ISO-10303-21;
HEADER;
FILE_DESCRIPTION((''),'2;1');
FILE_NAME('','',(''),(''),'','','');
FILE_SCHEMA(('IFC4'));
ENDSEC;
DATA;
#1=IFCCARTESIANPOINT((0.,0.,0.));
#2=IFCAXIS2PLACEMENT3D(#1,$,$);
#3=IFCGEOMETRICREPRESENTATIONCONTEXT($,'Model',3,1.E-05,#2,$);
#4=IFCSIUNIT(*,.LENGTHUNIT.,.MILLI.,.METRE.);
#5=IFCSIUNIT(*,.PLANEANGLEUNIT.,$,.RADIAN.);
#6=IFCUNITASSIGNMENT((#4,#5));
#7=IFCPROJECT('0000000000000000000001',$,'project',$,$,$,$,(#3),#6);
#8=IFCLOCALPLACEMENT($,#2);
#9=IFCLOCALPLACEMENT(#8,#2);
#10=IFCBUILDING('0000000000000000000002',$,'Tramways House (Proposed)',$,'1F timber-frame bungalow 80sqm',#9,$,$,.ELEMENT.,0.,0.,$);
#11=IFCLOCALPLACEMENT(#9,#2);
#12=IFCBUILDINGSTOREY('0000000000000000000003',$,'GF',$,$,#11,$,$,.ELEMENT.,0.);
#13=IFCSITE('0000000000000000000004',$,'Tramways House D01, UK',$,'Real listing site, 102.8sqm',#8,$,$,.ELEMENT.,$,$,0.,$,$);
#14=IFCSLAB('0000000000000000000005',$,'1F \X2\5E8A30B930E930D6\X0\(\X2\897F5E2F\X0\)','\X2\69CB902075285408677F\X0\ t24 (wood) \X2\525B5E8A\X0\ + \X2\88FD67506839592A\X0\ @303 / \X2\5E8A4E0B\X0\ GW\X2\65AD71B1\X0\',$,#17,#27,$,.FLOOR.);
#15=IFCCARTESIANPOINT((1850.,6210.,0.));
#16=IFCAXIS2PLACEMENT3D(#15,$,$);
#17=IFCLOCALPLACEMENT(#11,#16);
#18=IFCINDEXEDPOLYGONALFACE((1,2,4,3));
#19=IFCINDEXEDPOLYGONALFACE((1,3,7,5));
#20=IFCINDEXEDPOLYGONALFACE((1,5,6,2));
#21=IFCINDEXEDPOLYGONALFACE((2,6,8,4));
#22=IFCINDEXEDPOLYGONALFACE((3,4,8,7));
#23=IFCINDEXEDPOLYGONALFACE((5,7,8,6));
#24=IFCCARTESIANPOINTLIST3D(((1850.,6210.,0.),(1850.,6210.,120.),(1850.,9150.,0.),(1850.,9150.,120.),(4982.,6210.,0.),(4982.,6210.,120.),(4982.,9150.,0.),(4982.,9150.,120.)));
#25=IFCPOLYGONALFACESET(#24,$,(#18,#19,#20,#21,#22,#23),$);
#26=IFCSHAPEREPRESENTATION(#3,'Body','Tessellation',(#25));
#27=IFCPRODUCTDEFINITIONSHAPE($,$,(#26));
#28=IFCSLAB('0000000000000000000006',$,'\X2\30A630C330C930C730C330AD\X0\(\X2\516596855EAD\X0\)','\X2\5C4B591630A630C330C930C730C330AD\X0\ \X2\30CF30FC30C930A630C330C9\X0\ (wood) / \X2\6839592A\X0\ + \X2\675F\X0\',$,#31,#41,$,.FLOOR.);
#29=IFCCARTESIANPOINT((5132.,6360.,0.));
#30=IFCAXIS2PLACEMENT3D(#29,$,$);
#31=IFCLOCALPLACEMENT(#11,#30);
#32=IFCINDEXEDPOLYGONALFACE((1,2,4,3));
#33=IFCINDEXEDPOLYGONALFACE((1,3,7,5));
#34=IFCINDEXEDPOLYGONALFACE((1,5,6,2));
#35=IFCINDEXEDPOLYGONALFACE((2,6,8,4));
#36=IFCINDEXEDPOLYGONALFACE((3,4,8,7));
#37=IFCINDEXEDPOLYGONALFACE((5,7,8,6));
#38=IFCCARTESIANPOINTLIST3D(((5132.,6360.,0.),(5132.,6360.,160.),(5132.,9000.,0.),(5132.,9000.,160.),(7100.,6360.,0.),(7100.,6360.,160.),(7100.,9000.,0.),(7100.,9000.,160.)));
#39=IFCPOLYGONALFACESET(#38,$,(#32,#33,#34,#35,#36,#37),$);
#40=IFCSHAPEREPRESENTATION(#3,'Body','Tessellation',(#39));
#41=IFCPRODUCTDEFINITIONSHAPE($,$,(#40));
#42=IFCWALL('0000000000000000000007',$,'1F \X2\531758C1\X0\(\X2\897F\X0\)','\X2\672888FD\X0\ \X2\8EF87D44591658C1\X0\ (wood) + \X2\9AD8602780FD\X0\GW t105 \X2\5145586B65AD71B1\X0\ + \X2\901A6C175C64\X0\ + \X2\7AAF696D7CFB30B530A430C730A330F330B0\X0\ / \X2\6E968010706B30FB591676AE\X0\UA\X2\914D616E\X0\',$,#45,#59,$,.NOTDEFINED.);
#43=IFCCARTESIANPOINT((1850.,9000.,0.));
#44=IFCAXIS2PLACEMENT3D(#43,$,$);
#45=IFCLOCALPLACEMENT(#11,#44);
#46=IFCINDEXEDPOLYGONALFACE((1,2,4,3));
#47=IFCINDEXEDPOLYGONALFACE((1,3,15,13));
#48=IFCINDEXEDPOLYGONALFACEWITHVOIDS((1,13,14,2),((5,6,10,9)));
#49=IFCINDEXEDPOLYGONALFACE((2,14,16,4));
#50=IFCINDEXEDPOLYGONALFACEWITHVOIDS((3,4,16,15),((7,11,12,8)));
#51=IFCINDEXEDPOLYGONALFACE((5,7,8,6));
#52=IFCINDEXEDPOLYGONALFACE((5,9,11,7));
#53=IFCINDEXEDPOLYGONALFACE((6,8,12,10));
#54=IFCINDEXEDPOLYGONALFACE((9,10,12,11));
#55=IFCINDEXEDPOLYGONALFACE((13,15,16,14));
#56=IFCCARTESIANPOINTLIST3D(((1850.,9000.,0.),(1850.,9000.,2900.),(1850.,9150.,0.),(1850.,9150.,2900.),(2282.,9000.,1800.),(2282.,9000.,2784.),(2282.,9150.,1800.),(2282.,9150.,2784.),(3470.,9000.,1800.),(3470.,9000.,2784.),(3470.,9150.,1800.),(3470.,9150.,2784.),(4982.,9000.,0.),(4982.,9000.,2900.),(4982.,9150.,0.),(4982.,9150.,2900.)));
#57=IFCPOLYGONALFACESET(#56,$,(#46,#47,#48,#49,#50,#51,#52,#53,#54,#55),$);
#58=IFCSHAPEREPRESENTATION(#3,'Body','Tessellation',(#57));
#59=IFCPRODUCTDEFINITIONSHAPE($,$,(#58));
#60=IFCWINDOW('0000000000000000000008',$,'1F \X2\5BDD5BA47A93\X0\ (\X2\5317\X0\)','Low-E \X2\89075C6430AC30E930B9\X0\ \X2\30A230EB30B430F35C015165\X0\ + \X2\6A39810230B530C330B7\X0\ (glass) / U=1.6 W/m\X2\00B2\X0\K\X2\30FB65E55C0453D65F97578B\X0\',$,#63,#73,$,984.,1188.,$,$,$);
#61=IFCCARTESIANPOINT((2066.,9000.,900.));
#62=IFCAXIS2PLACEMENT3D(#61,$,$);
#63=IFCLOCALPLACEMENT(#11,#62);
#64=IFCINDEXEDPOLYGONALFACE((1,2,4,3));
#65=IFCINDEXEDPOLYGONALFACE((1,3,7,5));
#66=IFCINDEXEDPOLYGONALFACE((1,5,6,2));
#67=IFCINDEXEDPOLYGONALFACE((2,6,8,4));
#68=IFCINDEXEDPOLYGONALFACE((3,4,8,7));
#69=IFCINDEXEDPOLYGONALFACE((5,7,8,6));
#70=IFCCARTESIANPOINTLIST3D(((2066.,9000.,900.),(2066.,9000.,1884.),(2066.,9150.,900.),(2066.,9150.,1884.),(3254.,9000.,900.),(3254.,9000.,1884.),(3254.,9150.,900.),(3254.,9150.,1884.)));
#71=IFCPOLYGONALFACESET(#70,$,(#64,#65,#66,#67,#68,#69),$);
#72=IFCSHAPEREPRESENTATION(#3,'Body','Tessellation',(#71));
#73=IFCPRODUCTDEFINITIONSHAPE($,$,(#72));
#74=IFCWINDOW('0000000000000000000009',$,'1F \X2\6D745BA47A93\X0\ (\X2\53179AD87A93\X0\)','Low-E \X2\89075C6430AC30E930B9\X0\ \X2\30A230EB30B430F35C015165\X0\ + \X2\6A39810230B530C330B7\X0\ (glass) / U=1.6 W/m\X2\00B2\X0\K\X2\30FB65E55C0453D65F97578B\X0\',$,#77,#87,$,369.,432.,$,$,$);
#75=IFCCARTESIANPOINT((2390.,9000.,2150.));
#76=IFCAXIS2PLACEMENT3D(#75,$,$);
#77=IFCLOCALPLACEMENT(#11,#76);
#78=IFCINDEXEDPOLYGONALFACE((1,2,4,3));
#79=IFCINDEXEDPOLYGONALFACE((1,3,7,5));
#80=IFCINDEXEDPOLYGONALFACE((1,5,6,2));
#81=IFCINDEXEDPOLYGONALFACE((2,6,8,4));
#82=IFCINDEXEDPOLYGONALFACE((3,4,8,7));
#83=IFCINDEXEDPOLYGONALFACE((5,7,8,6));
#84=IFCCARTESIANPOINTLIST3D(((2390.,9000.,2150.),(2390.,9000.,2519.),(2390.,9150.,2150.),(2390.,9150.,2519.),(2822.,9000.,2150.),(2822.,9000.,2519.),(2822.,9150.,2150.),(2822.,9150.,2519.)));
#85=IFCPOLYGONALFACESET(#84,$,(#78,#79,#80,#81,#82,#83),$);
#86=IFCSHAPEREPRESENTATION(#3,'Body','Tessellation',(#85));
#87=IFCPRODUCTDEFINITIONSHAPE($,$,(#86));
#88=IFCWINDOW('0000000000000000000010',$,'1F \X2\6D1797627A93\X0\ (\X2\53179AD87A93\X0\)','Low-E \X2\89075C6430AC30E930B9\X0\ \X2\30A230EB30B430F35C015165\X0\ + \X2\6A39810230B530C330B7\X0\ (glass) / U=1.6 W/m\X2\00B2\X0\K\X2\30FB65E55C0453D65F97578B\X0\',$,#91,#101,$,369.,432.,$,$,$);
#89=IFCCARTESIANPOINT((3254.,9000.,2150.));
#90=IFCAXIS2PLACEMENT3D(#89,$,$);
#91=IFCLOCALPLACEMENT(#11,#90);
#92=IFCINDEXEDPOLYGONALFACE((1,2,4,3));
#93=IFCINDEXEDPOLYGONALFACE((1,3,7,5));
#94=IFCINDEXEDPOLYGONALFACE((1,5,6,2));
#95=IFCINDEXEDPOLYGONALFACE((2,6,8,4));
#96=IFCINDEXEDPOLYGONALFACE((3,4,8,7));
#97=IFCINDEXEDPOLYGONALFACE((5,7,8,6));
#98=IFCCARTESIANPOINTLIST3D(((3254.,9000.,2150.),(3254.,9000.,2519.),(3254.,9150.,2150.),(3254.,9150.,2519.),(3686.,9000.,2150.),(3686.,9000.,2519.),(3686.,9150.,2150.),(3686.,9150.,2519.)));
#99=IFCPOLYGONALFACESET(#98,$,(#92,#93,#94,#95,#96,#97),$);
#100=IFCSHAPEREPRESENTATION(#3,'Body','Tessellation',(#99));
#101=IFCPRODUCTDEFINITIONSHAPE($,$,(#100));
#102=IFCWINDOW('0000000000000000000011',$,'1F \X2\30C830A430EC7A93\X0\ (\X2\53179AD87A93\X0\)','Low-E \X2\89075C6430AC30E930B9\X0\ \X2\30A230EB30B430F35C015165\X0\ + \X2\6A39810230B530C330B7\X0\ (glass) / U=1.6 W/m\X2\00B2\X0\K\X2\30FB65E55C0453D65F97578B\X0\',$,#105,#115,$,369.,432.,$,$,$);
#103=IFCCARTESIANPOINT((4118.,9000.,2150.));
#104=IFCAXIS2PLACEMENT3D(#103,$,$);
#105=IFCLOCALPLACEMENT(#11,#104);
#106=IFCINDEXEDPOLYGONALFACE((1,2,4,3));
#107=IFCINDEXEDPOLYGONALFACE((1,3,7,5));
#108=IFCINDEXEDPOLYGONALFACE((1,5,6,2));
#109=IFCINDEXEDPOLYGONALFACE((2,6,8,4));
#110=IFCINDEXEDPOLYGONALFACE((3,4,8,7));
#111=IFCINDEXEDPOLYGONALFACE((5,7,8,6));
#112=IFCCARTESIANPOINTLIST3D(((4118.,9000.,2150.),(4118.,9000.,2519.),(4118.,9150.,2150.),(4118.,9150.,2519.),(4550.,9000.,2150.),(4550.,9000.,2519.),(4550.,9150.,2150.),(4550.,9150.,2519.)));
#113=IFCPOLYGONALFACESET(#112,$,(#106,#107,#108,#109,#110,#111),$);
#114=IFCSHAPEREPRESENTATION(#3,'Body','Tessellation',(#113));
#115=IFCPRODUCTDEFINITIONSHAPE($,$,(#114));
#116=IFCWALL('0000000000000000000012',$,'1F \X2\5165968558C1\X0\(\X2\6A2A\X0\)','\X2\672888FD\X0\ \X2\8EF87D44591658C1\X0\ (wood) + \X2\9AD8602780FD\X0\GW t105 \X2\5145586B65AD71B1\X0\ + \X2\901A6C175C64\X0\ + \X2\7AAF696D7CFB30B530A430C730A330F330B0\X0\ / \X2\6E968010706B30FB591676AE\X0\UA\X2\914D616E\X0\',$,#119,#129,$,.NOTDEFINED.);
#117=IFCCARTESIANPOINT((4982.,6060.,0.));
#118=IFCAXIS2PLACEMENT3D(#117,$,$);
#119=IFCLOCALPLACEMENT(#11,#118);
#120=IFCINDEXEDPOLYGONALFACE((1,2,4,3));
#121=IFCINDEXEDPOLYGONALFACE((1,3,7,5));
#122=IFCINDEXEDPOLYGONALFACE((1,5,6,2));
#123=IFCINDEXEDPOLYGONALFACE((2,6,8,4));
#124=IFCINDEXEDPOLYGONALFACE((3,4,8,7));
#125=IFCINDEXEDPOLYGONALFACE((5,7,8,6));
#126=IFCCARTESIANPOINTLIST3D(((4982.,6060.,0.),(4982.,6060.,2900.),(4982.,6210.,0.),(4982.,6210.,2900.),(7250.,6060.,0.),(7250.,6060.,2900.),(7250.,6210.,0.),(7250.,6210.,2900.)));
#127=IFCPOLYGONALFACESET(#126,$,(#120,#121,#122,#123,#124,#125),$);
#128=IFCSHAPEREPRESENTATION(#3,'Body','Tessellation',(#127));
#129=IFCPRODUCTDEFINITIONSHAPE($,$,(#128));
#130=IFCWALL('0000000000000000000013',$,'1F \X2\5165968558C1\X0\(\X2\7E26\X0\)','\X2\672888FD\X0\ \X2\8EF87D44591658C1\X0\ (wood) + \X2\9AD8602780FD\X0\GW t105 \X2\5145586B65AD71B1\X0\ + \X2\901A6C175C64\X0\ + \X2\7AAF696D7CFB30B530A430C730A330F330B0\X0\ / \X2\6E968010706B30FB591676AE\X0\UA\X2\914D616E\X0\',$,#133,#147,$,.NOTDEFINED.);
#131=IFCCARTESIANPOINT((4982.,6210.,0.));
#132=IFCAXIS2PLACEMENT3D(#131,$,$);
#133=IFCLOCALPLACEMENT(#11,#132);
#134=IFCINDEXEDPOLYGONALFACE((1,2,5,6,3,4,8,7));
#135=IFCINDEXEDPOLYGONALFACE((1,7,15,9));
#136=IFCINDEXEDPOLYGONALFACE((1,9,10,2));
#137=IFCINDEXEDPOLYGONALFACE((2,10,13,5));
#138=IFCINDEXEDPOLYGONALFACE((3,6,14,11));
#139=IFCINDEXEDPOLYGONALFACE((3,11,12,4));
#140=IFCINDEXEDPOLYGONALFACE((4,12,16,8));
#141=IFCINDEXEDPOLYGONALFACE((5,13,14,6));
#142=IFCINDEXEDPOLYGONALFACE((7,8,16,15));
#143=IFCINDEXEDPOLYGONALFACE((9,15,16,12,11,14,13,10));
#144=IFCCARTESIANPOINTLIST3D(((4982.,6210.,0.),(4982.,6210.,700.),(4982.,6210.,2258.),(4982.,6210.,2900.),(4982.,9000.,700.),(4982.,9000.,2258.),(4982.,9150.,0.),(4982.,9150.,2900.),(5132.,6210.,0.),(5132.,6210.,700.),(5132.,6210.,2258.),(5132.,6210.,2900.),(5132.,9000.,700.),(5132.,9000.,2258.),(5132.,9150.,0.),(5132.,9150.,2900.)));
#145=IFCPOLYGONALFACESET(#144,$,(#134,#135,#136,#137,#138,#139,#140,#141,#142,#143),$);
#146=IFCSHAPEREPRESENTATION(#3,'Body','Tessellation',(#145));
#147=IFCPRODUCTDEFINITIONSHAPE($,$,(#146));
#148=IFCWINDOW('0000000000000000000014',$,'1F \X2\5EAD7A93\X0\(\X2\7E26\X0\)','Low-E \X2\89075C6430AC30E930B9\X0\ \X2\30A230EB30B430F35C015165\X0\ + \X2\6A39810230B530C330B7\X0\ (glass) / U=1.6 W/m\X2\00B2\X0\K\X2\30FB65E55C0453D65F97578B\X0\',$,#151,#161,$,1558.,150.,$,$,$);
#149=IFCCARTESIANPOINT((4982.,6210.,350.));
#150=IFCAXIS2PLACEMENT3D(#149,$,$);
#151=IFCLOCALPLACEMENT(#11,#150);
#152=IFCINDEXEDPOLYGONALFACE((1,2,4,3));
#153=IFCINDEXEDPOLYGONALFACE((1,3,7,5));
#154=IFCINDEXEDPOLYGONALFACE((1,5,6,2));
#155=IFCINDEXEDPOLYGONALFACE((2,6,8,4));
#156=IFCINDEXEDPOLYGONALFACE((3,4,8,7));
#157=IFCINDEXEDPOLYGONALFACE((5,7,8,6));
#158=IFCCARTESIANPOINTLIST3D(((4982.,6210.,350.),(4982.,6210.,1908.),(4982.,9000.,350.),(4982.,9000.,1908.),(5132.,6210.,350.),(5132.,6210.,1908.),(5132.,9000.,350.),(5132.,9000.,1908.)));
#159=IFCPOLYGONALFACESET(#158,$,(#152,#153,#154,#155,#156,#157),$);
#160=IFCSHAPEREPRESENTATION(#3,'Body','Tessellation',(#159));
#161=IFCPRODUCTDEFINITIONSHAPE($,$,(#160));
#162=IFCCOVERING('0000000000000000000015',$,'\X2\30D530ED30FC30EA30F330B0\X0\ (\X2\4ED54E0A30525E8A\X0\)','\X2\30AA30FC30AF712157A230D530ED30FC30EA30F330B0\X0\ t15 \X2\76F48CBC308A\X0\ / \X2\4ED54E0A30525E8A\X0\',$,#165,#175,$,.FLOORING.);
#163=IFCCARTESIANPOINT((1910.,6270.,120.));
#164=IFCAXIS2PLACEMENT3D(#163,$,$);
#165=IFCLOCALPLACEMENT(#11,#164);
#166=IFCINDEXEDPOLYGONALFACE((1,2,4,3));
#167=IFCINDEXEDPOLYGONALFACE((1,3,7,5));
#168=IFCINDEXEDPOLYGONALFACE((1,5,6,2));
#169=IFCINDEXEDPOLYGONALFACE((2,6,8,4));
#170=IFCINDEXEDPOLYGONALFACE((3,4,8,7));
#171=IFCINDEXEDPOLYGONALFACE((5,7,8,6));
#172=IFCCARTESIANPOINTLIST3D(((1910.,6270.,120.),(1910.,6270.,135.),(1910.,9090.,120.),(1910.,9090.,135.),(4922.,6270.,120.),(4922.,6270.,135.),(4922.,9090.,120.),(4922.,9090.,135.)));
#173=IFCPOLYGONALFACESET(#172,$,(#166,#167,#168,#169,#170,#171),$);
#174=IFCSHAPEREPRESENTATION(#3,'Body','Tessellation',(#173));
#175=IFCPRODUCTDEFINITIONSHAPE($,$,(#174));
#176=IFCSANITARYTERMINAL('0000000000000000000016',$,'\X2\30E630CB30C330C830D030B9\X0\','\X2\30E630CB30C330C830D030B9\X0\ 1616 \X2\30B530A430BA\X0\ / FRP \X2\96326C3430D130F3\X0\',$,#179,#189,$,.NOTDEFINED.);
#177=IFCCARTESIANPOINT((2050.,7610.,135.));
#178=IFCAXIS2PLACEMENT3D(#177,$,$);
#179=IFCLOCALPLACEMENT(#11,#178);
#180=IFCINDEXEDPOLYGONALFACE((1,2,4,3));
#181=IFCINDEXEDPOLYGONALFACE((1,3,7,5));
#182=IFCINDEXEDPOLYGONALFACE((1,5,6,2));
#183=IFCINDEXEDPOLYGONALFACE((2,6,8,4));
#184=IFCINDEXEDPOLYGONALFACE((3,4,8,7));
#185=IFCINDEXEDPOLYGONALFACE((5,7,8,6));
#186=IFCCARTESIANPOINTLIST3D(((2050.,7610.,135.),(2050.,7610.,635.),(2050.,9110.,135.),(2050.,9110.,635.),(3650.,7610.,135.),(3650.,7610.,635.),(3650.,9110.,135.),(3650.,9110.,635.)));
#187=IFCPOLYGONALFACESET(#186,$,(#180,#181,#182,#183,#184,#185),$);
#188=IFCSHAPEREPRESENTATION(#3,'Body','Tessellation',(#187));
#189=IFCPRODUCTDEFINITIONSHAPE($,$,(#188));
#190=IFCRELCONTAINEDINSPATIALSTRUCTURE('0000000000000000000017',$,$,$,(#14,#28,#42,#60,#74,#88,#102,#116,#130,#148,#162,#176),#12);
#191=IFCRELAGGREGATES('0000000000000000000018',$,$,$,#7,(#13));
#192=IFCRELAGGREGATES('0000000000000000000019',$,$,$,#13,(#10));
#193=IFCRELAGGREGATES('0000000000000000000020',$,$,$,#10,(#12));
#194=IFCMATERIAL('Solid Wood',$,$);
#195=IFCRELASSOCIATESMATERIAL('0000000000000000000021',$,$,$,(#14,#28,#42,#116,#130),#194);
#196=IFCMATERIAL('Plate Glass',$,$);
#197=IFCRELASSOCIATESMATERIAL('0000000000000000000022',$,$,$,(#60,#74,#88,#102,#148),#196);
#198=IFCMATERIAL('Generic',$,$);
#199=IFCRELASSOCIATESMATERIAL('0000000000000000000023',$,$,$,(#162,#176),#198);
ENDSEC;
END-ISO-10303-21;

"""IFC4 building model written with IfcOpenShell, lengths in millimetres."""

from ifc_helpers import new_model, si_unit, frame, frame_2d, origin, place, context, project, spatial, rectangle, extrude, material, element, fill, save


model = new_model("IFC4")

# Units and contexts
model_context = context("Model", 3, precision=1e-05, world=origin())
ifc_project = project(units=[si_unit("LENGTHUNIT", "METRE", prefix="MILLI"), si_unit("PLANEANGLEUNIT", "RADIAN")], contexts=[model_context])

# Site, building, storey
site_placement = place(None, origin())
site = spatial("IfcSite", under=ifc_project, at=site_placement, Name="Tramways House D01, UK", ObjectType="Real listing site, 102.8sqm", CompositionType="ELEMENT", RefElevation=0.0)
building_placement = place(site_placement, origin())
building = spatial("IfcBuilding", under=site, at=building_placement, Name="Tramways House (Proposed)", ObjectType="1F timber-frame bungalow 80sqm", CompositionType="ELEMENT", ElevationOfRefHeight=0.0, ElevationOfTerrain=0.0)
storey_placement = place(building_placement, origin())
storey = spatial("IfcBuildingStorey", under=building, at=storey_placement, Name="GF", CompositionType="ELEMENT", Elevation=0.0)

# Slabs
ifc_material_1 = material(Name="Solid Wood")
slab_1_placement = place(storey_placement, frame((1850.0, 6210.0, 0.0)))
element("IfcSlab", 1, at=slab_1_placement, inside=storey, material=ifc_material_1, Name="1F 床スラブ(西帯)", Description="構造用合板 t24 (wood) 剛床 + 製材根太 @303 / 床下 GW断熱", PredefinedType="FLOOR", context=model_context, shape_type="SweptSolid", body=[
    extrude(rectangle(XDim=3132.0, YDim=2940.0, at=frame_2d((1566.0, 1470.0))), frame((1850.0, 6210.0, 0.0)), (0.0, 0.0, 1.0), 120.0),
])
slab_2_placement = place(storey_placement, frame((5132.0, 6360.0, 0.0)))
element("IfcSlab", 2, at=slab_2_placement, inside=storey, material=ifc_material_1, Name="ウッドデッキ(入隅庭)", Description="屋外ウッドデッキ ハードウッド (wood) / 根太 + 束", PredefinedType="FLOOR", context=model_context, shape_type="SweptSolid", body=[
    extrude(rectangle(XDim=1968.0, YDim=2640.0, at=frame_2d((984.0, 1320.0))), frame((5132.0, 6360.0, 0.0)), (0.0, 0.0, 1.0), 160.0),
])

# Wall, openings, windows
wall_1_placement = place(storey_placement, frame((1850.0, 9000.0, 0.0)))
wall_1 = element("IfcWall", 3, at=wall_1_placement, inside=storey, material=ifc_material_1, Name="1F 北壁(西)", Description="木製 軸組外壁 (wood) + 高性能GW t105 充填断熱 + 通気層 + 窯業系サイディング / 準耐火・外皮UA配慮", PredefinedType="NOTDEFINED", context=model_context, shape_type="SweptSolid", body=[
    extrude(rectangle(XDim=3132.0, YDim=150.0, at=frame_2d((1566.0, 75.0))), frame((1850.0, 9000.0, 0.0)), (0.0, 0.0, 1.0), 2900.0),
])
opening_1_placement = place(storey_placement, frame((2066.0, 9000.0, 900.0)))
opening_1 = element("IfcOpeningElement", 4, at=opening_1_placement, cuts=wall_1, PredefinedType="NOTDEFINED", context=model_context, shape_type="SweptSolid", body=[
    extrude(rectangle(XDim=1188.0, YDim=150.0, at=frame_2d((594.0, 75.0))), frame((2066.0, 9000.0, 900.0)), (0.0, 0.0, 1.0), 984.0),
])
opening_2_placement = place(storey_placement, frame((2390.0, 9000.0, 2150.0)))
opening_2 = element("IfcOpeningElement", 5, at=opening_2_placement, cuts=wall_1, PredefinedType="NOTDEFINED", context=model_context, shape_type="SweptSolid", body=[
    extrude(rectangle(XDim=432.0, YDim=150.0, at=frame_2d((216.0, 75.0))), frame((2390.0, 9000.0, 2150.0)), (0.0, 0.0, 1.0), 369.0),
])
opening_3_placement = place(storey_placement, frame((3254.0, 9000.0, 2150.0)))
opening_3 = element("IfcOpeningElement", 6, at=opening_3_placement, cuts=wall_1, PredefinedType="NOTDEFINED", context=model_context, shape_type="SweptSolid", body=[
    extrude(rectangle(XDim=432.0, YDim=150.0, at=frame_2d((216.0, 75.0))), frame((3254.0, 9000.0, 2150.0)), (0.0, 0.0, 1.0), 369.0),
])
opening_4_placement = place(storey_placement, frame((4118.0, 9000.0, 2150.0)))
opening_4 = element("IfcOpeningElement", 7, at=opening_4_placement, cuts=wall_1, PredefinedType="NOTDEFINED", context=model_context, shape_type="SweptSolid", body=[
    extrude(rectangle(XDim=432.0, YDim=150.0, at=frame_2d((216.0, 75.0))), frame((4118.0, 9000.0, 2150.0)), (0.0, 0.0, 1.0), 369.0),
])
ifc_material_2 = material(Name="Plate Glass")
window_1_placement = place(storey_placement, frame((2066.0, 9000.0, 900.0)))
window_1 = element("IfcWindow", 8, at=window_1_placement, inside=storey, material=ifc_material_2, Name="1F 寝室窓 (北)", Description="Low-E 複層ガラス アルゴン封入 + 樹脂サッシ (glass) / U=1.6 W/m²K・日射取得型", OverallHeight=984.0, OverallWidth=1188.0, context=model_context, shape_type="SweptSolid", body=[
    extrude(rectangle(XDim=1188.0, YDim=150.0, at=frame_2d((594.0, 75.0))), frame((2066.0, 9000.0, 900.0)), (0.0, 0.0, 1.0), 984.0),
])
fill(opening_1, window_1)
window_2_placement = place(storey_placement, frame((2390.0, 9000.0, 2150.0)))
window_2 = element("IfcWindow", 9, at=window_2_placement, inside=storey, material=ifc_material_2, Name="1F 浴室窓 (北高窓)", Description="Low-E 複層ガラス アルゴン封入 + 樹脂サッシ (glass) / U=1.6 W/m²K・日射取得型", OverallHeight=369.0, OverallWidth=432.0, context=model_context, shape_type="SweptSolid", body=[
    extrude(rectangle(XDim=432.0, YDim=150.0, at=frame_2d((216.0, 75.0))), frame((2390.0, 9000.0, 2150.0)), (0.0, 0.0, 1.0), 369.0),
])
fill(opening_2, window_2)
window_3_placement = place(storey_placement, frame((3254.0, 9000.0, 2150.0)))
window_3 = element("IfcWindow", 10, at=window_3_placement, inside=storey, material=ifc_material_2, Name="1F 洗面窓 (北高窓)", Description="Low-E 複層ガラス アルゴン封入 + 樹脂サッシ (glass) / U=1.6 W/m²K・日射取得型", OverallHeight=369.0, OverallWidth=432.0, context=model_context, shape_type="SweptSolid", body=[
    extrude(rectangle(XDim=432.0, YDim=150.0, at=frame_2d((216.0, 75.0))), frame((3254.0, 9000.0, 2150.0)), (0.0, 0.0, 1.0), 369.0),
])
fill(opening_3, window_3)
window_4_placement = place(storey_placement, frame((4118.0, 9000.0, 2150.0)))
window_4 = element("IfcWindow", 11, at=window_4_placement, inside=storey, material=ifc_material_2, Name="1F トイレ窓 (北高窓)", Description="Low-E 複層ガラス アルゴン封入 + 樹脂サッシ (glass) / U=1.6 W/m²K・日射取得型", OverallHeight=369.0, OverallWidth=432.0, context=model_context, shape_type="SweptSolid", body=[
    extrude(rectangle(XDim=432.0, YDim=150.0, at=frame_2d((216.0, 75.0))), frame((4118.0, 9000.0, 2150.0)), (0.0, 0.0, 1.0), 369.0),
])
fill(opening_4, window_4)

# Wall
wall_2_placement = place(storey_placement, frame((4982.0, 6060.0, 0.0)))
element("IfcWall", 12, at=wall_2_placement, inside=storey, material=ifc_material_1, Name="1F 入隅壁(横)", Description="木製 軸組外壁 (wood) + 高性能GW t105 充填断熱 + 通気層 + 窯業系サイディング / 準耐火・外皮UA配慮", PredefinedType="NOTDEFINED", context=model_context, shape_type="SweptSolid", body=[
    extrude(rectangle(XDim=2268.0, YDim=150.0, at=frame_2d((1134.0, 75.0))), frame((4982.0, 6060.0, 0.0)), (0.0, 0.0, 1.0), 2900.0),
])

# Wall, opening, window
wall_3_placement = place(storey_placement, frame((4982.0, 6210.0, 0.0)))
wall_3 = element("IfcWall", 13, at=wall_3_placement, inside=storey, material=ifc_material_1, Name="1F 入隅壁(縦)", Description="木製 軸組外壁 (wood) + 高性能GW t105 充填断熱 + 通気層 + 窯業系サイディング / 準耐火・外皮UA配慮", PredefinedType="NOTDEFINED", context=model_context, shape_type="SweptSolid", body=[
    extrude(rectangle(XDim=150.0, YDim=2940.0, at=frame_2d((75.0, 1470.0))), frame((4982.0, 6210.0, 0.0)), (0.0, 0.0, 1.0), 2900.0),
])
opening_5_placement = place(storey_placement, frame((4982.0, 6210.0, 350.0)))
opening_5 = element("IfcOpeningElement", 14, at=opening_5_placement, cuts=wall_3, PredefinedType="NOTDEFINED", context=model_context, shape_type="SweptSolid", body=[
    extrude(rectangle(XDim=150.0, YDim=2790.0, at=frame_2d((75.0, 1395.0))), frame((4982.0, 6210.0, 350.0)), (0.0, 0.0, 1.0), 1558.0),
])
window_5_placement = place(storey_placement, frame((4982.0, 6210.0, 350.0)))
window_5 = element("IfcWindow", 15, at=window_5_placement, inside=storey, material=ifc_material_2, Name="1F 庭窓(縦)", Description="Low-E 複層ガラス アルゴン封入 + 樹脂サッシ (glass) / U=1.6 W/m²K・日射取得型", OverallHeight=1558.0, OverallWidth=150.0, context=model_context, shape_type="SweptSolid", body=[
    extrude(rectangle(XDim=150.0, YDim=2790.0, at=frame_2d((75.0, 1395.0))), frame((4982.0, 6210.0, 350.0)), (0.0, 0.0, 1.0), 1558.0),
])
fill(opening_5, window_5)

# Covering
ifc_material_3 = material(Name="Generic")
covering_placement = place(storey_placement, frame((1910.0, 6270.0, 120.0)))
element("IfcCovering", 16, at=covering_placement, inside=storey, material=ifc_material_3, Name="フローリング (仕上げ床)", Description="オーク無垢フローリング t15 直貼り / 仕上げ床", PredefinedType="FLOORING", context=model_context, shape_type="SweptSolid", body=[
    extrude(rectangle(XDim=3012.0, YDim=2820.0, at=frame_2d((1506.0, 1410.0))), frame((1910.0, 6270.0, 120.0)), (0.0, 0.0, 1.0), 15.0),
])

# Sanitary terminal
sanitary_terminal_1_placement = place(storey_placement, frame((2050.0, 7610.0, 135.0)))
element("IfcSanitaryTerminal", 17, at=sanitary_terminal_1_placement, inside=storey, material=ifc_material_3, Name="ユニットバス", Description="ユニットバス 1616 サイズ / FRP 防水パン", PredefinedType="NOTDEFINED", context=model_context, shape_type="SweptSolid", body=[
    extrude(rectangle(XDim=1600.0, YDim=1500.0, at=frame_2d((800.0, 750.0))), frame((2050.0, 7610.0, 135.0)), (0.0, 0.0, 1.0), 500.0),
])

save(model, "model.ifc")
